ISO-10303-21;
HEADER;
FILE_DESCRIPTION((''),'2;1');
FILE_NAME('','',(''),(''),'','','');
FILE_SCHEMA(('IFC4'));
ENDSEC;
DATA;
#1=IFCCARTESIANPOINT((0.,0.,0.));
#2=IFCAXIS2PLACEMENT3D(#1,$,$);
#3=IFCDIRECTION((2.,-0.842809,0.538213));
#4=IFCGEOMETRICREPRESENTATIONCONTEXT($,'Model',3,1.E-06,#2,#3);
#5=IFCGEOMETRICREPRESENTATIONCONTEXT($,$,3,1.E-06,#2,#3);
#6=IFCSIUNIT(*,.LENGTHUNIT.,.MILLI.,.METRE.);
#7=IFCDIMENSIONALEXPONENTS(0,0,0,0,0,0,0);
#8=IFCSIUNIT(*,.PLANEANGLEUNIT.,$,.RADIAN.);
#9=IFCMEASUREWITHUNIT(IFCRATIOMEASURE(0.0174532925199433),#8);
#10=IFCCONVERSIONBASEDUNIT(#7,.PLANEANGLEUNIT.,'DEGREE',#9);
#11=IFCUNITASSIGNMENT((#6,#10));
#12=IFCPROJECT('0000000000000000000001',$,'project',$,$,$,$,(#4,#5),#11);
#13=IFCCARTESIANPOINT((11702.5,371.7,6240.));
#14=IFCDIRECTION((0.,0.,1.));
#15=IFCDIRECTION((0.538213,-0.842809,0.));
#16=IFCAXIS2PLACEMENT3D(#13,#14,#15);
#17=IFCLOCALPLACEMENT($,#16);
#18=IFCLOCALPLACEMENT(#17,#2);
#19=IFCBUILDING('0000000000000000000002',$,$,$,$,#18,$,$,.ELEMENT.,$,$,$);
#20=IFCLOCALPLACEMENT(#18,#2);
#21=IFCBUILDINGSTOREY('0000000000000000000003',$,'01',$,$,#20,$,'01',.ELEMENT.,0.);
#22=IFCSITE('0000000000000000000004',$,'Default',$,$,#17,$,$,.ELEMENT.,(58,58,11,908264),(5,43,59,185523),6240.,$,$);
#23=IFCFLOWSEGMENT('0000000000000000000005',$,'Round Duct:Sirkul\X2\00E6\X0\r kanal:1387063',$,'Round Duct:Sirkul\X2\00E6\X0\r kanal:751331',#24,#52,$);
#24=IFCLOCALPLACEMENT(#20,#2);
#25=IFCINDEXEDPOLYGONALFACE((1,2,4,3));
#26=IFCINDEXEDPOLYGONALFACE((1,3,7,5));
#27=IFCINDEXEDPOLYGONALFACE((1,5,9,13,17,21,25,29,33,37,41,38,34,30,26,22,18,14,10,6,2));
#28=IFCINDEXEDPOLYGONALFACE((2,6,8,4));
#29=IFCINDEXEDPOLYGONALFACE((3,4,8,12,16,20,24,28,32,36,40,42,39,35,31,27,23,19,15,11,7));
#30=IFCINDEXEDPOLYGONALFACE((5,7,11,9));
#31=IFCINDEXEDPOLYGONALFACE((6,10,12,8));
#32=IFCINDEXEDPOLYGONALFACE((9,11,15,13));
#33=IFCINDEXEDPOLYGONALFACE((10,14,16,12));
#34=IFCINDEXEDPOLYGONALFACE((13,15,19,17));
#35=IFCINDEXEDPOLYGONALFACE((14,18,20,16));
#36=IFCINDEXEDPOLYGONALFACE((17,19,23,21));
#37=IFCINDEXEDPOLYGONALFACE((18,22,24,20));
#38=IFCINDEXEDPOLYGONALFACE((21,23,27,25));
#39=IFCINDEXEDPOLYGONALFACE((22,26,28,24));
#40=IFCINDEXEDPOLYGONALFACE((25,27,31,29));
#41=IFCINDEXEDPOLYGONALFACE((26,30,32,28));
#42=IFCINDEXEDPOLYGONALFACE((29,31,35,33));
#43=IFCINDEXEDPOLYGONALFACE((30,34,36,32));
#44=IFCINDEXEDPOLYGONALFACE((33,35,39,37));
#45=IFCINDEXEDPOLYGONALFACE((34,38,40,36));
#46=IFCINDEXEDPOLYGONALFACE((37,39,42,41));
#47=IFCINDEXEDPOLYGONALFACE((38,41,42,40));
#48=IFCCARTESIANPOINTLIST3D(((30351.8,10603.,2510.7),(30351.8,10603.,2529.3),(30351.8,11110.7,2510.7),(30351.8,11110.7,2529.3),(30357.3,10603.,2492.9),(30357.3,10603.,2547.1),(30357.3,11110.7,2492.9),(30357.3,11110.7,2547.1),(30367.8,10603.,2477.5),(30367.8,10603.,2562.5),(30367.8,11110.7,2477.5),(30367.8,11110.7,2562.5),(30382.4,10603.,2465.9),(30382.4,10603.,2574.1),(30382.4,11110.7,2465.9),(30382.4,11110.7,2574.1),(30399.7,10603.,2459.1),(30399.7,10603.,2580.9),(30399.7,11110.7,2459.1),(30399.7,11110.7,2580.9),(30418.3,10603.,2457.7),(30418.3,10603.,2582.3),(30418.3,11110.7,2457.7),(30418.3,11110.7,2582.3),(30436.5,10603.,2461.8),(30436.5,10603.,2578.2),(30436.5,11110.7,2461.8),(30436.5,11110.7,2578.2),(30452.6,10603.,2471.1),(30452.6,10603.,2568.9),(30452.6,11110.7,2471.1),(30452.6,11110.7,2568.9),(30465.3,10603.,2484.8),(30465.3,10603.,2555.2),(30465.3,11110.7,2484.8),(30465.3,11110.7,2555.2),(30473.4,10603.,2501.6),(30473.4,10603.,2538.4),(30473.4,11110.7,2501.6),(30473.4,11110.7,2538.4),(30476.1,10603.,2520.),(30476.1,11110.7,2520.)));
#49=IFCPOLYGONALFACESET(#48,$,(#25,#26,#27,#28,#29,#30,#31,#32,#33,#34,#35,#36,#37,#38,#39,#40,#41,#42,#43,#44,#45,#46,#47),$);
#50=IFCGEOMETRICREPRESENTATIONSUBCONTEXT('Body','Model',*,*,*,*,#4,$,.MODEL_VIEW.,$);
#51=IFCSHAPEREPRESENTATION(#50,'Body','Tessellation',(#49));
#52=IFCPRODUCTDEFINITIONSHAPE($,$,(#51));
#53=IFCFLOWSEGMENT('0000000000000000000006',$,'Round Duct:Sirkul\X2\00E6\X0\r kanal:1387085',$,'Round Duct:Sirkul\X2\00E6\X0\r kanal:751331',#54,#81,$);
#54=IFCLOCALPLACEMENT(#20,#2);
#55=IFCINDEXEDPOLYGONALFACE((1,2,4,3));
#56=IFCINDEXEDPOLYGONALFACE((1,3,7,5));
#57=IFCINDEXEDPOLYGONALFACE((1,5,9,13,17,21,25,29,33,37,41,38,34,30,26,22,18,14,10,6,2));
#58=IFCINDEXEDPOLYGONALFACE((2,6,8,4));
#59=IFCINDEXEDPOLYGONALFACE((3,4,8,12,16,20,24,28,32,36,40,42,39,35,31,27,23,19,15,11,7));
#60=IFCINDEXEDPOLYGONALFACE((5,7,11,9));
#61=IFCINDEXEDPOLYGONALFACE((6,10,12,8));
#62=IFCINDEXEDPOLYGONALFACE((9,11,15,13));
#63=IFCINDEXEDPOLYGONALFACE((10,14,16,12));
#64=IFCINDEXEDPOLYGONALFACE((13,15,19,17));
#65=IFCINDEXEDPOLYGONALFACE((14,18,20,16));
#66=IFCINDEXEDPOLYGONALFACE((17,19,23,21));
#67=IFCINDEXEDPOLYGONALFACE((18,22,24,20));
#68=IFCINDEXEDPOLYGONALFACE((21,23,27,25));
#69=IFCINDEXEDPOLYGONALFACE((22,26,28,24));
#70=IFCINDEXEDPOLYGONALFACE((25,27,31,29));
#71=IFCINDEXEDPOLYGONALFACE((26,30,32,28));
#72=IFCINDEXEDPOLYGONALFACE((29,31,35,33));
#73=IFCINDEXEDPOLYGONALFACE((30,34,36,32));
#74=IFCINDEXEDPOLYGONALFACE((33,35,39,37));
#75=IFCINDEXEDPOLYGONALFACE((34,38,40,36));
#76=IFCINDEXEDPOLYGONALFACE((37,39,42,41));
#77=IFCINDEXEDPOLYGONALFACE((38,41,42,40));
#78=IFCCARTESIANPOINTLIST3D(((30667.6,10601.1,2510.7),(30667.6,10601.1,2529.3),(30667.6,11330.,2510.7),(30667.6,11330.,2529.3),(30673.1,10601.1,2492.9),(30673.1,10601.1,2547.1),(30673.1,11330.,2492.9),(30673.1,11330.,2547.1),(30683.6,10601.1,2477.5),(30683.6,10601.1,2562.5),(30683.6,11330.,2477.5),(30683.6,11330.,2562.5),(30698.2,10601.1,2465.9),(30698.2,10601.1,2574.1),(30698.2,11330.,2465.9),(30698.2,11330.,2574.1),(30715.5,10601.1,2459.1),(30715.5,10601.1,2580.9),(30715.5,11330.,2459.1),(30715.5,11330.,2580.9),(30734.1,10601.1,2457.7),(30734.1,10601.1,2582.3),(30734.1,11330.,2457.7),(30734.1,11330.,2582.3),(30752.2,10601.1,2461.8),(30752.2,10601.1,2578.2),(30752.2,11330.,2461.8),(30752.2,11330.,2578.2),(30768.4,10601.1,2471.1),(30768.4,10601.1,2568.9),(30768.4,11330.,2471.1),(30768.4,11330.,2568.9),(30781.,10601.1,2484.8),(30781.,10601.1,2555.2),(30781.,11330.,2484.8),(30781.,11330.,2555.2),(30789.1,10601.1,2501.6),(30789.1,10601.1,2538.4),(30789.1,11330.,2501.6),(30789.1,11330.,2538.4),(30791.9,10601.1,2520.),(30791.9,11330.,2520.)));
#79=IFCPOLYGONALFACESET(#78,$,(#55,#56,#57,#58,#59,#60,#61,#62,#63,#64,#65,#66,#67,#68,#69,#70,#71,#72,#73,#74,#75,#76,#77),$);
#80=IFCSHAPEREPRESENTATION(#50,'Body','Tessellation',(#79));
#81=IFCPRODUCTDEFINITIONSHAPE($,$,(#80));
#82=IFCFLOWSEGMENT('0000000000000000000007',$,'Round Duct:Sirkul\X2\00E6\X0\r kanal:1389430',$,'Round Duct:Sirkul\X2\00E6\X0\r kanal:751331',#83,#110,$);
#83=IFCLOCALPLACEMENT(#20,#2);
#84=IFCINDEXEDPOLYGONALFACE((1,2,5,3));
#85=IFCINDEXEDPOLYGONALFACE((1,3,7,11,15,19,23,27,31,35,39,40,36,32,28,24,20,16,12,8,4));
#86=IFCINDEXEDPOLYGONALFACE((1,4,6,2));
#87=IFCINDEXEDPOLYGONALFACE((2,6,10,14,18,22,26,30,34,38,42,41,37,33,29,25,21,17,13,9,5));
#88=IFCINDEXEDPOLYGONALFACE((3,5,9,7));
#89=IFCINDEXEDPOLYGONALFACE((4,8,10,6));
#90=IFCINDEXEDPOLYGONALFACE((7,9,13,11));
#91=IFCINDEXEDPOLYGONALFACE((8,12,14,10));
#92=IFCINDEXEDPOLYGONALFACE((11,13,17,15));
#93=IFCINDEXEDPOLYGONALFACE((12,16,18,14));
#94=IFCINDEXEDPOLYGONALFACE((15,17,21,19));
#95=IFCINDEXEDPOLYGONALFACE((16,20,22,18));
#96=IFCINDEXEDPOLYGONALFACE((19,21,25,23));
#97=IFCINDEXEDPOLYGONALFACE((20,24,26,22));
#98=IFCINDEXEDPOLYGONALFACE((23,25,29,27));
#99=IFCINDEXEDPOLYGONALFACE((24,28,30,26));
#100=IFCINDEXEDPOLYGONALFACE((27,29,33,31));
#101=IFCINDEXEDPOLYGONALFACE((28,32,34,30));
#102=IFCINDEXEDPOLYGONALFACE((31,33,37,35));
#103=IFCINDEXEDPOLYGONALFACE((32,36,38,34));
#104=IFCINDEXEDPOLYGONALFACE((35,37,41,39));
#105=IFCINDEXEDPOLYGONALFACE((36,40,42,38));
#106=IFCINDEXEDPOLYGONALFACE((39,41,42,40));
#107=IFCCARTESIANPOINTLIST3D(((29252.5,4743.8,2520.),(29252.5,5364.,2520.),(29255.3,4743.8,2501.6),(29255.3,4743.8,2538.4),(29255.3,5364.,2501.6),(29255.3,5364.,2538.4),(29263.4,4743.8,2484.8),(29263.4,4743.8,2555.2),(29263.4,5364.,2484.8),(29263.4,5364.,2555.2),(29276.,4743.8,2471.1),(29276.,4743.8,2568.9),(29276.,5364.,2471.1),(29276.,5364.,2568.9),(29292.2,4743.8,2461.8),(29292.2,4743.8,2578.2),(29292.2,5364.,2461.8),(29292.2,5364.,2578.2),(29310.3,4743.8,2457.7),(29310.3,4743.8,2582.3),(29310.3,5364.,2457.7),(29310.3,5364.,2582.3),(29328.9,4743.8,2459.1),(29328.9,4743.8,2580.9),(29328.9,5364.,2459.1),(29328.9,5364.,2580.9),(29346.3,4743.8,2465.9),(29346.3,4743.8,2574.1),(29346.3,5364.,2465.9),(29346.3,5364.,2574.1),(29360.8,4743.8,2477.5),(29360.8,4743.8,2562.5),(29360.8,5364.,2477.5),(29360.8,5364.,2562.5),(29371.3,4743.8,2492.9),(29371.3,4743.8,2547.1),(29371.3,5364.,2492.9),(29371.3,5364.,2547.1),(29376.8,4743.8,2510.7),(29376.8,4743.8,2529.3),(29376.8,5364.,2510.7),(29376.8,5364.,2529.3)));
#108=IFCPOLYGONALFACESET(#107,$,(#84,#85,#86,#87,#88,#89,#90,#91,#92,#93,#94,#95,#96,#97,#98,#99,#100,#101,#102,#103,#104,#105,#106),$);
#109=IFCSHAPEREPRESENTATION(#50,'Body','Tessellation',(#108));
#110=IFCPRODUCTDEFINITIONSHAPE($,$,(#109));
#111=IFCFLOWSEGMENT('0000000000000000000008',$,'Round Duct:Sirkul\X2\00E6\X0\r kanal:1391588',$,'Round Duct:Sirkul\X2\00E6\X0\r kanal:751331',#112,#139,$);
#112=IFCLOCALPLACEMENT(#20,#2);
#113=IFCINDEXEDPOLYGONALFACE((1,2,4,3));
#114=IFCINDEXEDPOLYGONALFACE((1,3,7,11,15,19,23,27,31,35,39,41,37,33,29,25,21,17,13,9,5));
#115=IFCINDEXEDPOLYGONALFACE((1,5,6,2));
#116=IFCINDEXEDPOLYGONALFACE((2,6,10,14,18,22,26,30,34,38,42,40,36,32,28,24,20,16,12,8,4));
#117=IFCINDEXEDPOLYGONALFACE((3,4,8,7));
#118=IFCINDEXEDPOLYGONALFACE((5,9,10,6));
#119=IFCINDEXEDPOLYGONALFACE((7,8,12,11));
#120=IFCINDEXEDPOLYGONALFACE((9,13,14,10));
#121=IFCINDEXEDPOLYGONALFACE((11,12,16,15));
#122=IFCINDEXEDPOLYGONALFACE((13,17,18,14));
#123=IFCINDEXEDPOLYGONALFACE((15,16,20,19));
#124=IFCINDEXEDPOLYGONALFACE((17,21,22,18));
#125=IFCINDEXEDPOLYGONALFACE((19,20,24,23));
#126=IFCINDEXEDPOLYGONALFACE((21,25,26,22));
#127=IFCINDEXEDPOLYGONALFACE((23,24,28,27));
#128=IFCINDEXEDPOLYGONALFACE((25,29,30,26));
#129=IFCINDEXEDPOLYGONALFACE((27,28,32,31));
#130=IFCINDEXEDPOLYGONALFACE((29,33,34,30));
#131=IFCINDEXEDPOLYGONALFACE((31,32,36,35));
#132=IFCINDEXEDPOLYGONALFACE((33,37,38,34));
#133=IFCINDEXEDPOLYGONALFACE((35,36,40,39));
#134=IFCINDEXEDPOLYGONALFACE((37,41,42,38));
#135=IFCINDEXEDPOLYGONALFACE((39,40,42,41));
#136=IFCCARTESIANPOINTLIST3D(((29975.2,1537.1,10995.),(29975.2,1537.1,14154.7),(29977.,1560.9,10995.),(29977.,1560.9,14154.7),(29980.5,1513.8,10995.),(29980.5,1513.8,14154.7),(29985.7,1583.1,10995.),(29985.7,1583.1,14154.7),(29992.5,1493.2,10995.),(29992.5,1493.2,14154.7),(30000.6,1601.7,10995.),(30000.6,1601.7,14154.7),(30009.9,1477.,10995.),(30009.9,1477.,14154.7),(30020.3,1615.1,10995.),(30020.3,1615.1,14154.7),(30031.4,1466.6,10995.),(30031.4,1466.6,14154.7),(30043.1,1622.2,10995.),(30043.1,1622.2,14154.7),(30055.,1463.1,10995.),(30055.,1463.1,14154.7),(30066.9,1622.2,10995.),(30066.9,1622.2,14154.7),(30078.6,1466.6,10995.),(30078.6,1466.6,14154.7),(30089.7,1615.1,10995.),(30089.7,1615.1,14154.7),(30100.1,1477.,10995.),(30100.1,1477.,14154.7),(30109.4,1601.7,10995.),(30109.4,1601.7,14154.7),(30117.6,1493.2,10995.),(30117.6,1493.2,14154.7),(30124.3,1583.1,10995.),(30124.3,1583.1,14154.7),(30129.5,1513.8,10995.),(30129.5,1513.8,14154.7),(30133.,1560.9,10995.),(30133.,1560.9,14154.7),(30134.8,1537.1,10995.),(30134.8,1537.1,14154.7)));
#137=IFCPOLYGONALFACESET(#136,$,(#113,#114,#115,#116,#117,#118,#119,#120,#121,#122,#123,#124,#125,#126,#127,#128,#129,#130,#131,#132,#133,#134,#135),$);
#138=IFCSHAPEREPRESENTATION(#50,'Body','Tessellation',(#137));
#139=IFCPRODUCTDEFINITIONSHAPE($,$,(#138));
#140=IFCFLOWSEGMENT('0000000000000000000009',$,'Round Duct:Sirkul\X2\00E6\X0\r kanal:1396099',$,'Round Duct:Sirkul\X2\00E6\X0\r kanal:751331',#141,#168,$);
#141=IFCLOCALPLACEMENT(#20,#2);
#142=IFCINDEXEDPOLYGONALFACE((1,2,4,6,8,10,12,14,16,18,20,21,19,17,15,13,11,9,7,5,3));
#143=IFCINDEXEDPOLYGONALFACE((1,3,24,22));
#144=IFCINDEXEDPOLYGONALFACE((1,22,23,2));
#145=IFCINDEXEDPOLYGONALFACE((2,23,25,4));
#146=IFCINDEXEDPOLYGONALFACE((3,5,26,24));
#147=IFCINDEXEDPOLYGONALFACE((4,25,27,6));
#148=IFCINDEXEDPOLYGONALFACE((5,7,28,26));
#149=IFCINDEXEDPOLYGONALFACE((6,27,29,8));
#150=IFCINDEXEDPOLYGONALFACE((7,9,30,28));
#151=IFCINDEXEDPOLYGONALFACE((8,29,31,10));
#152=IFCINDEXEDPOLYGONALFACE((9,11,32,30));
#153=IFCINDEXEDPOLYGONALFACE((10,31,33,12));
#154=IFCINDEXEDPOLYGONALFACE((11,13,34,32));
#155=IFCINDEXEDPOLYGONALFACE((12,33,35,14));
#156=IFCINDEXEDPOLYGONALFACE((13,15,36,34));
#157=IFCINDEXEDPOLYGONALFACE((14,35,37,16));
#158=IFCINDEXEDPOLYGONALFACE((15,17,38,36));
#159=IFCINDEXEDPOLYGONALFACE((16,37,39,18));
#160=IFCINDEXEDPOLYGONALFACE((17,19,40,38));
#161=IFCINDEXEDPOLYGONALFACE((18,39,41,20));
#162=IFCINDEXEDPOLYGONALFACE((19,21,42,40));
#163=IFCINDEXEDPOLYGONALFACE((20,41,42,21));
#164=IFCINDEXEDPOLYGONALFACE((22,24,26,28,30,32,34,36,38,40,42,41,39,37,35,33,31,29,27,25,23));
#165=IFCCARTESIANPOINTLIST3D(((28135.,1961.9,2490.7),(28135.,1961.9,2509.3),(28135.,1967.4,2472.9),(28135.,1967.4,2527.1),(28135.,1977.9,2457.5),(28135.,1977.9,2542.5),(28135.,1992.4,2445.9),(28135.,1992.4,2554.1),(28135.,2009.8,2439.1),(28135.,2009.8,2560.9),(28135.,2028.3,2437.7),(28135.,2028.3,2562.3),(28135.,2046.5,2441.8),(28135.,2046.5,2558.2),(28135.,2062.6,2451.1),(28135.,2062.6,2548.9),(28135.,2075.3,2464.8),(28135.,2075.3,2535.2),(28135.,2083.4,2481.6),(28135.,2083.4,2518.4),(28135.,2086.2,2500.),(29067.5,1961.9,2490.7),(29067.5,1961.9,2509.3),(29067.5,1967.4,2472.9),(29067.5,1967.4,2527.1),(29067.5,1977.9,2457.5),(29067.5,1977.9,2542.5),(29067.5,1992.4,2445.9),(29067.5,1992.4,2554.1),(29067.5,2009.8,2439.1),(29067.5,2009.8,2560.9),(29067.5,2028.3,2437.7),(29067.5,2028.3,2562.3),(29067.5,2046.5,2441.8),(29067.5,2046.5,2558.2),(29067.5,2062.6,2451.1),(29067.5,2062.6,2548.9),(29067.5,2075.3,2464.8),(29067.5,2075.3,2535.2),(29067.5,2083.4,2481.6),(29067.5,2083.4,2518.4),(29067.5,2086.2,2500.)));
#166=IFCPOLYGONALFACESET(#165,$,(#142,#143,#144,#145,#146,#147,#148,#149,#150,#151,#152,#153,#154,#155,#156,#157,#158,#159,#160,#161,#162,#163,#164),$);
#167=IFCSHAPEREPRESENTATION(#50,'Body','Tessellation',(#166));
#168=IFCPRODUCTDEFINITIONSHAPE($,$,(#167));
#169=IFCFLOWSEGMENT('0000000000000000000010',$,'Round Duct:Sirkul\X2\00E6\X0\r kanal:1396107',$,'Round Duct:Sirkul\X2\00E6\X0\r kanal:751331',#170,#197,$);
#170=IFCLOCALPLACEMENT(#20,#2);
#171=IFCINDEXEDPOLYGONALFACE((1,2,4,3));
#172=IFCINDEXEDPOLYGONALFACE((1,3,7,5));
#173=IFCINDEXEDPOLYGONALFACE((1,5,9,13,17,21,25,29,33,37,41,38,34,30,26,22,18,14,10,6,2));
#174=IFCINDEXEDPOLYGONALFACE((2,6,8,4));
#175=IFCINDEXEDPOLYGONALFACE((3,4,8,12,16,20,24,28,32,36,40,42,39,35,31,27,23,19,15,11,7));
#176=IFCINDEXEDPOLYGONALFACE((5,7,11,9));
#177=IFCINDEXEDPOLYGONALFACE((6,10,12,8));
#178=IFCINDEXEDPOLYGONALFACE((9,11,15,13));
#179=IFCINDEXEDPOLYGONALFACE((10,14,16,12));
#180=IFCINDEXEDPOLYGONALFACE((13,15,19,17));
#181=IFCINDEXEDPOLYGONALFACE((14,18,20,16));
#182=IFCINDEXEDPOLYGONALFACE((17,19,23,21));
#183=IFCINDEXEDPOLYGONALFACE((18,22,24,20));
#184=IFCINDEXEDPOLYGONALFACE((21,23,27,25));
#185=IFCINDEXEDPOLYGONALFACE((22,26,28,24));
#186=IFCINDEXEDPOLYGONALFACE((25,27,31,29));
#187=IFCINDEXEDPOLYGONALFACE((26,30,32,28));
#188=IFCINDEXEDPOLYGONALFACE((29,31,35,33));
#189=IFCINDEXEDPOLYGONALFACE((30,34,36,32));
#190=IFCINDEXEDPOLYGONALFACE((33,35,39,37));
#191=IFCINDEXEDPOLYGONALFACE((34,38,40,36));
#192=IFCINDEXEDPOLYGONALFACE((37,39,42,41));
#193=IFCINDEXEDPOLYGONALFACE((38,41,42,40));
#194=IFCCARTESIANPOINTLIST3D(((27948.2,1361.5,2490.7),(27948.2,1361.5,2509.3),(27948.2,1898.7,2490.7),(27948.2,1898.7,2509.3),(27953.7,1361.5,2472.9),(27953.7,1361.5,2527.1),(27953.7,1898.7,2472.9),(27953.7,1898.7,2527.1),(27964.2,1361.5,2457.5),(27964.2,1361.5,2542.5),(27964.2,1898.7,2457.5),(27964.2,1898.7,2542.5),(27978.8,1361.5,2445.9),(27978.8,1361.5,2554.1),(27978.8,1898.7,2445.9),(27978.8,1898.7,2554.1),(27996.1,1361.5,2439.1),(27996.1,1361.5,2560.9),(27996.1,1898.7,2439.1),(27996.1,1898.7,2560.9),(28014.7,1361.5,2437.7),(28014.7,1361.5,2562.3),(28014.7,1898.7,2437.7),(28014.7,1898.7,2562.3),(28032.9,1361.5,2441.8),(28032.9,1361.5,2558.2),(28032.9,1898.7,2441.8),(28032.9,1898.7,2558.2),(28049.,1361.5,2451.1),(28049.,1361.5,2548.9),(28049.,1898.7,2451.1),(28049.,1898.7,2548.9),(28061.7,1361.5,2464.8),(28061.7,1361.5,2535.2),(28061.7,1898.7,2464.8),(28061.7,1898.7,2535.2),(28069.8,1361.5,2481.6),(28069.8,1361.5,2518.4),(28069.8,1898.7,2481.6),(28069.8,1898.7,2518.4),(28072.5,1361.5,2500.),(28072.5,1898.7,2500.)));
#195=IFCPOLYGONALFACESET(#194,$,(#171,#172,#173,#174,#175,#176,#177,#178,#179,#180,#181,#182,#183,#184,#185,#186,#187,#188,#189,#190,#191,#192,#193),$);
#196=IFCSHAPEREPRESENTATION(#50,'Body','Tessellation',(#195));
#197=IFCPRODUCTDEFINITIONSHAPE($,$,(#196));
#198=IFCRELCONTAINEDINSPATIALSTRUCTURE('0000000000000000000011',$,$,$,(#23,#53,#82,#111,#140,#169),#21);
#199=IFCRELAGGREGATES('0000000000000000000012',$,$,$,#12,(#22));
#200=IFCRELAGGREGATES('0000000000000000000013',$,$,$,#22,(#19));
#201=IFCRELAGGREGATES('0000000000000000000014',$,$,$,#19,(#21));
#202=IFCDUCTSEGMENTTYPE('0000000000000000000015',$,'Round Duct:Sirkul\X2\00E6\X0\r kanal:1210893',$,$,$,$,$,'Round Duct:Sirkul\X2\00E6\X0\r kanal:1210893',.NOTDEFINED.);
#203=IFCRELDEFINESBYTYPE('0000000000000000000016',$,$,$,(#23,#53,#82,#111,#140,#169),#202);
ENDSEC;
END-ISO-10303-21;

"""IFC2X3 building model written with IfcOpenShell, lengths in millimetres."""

from ifc_helpers import new_model, entity, si_unit, converted_unit, direction, frame, frame_2d, origin, origin_2d_with_axis, place, context, subcontext, project, spatial, circle, extrude, type_object, element, save


model = new_model("IFC2X3")

# Units and contexts
model_context = context("Model", 3, precision=1e-06, world=origin(), true_north=direction((2.0, -0.842809, 0.538213)))
context_of_model = context(None, 3, precision=1e-06, world=origin(), true_north=direction((2.0, -0.842809, 0.538213)))
body_context = subcontext(model_context, "Body", "Model", "MODEL_VIEW")
ifc_project = project(units=[si_unit("LENGTHUNIT", "METRE", prefix="MILLI"), converted_unit("PLANEANGLEUNIT", "DEGREE", entity("IfcRatioMeasure", 0.0174532925199433), si_unit("PLANEANGLEUNIT", "RADIAN"), dimensions=[0, 0, 0, 0, 0, 0, 0])], contexts=[model_context, context_of_model])

# Site, building, storey
site_placement = place(None, frame((11702.5, 371.7, 6240.0), z_axis=(0.0, 0.0, 1.0), x_axis=(0.538213, -0.842809, 0.0)))
site = spatial("IfcSite", under=ifc_project, at=site_placement, Name="Default", CompositionType="ELEMENT", RefLatitude=(58, 58, 11, 908264), RefLongitude=(5, 43, 59, 185523), RefElevation=6240.0)
building_placement = place(site_placement, origin())
building = spatial("IfcBuilding", under=site, at=building_placement, CompositionType="ELEMENT")
storey_placement = place(building_placement, origin())
storey = spatial("IfcBuildingStorey", under=building, at=storey_placement, Name="01", LongName="01", CompositionType="ELEMENT", Elevation=0.0)

# Flow segments
duct_segment_type_1 = type_object("IfcDuctSegmentType", Name="Round Duct:Sirkulær kanal:1210893", ElementType="Round Duct:Sirkulær kanal:1210893", PredefinedType="NOTDEFINED")
flow_segment_1_placement = place(storey_placement, origin())
element("IfcFlowSegment", 1, at=flow_segment_1_placement, inside=storey, type_object=duct_segment_type_1, Name="Round Duct:Sirkulær kanal:1387063", ObjectType="Round Duct:Sirkulær kanal:751331", context=body_context, shape_type="SweptSolid", body=[
    extrude(circle(Radius=62.5, at=origin_2d_with_axis()), frame((30413.6, 10603.0, 2520.0), z_axis=(0.0, 1.0, 0.0), x_axis=(1.0, 0.0, 0.0)), (0.0, 0.0, 1.0), 507.7),
])
flow_segment_2_placement = place(storey_placement, origin())
element("IfcFlowSegment", 2, at=flow_segment_2_placement, inside=storey, type_object=duct_segment_type_1, Name="Round Duct:Sirkulær kanal:1387085", ObjectType="Round Duct:Sirkulær kanal:751331", context=body_context, shape_type="SweptSolid", body=[
    extrude(circle(Radius=62.5, at=origin_2d_with_axis()), frame((30729.4, 10601.1, 2520.0), z_axis=(0.0, 1.0, 0.0), x_axis=(1.0, 0.0, 0.0)), (0.0, 0.0, 1.0), 728.9),
])
flow_segment_3_placement = place(storey_placement, origin())
element("IfcFlowSegment", 3, at=flow_segment_3_placement, inside=storey, type_object=duct_segment_type_1, Name="Round Duct:Sirkulær kanal:1389430", ObjectType="Round Duct:Sirkulær kanal:751331", context=body_context, shape_type="SweptSolid", body=[
    extrude(circle(Radius=62.5, at=origin_2d_with_axis()), frame((29315.0, 4743.8, 2520.0), z_axis=(0.0, 1.0, 0.0), x_axis=(-1.0, 0.0, 0.0)), (0.0, 0.0, 1.0), 620.2),
])
flow_segment_4_placement = place(storey_placement, origin())
element("IfcFlowSegment", 4, at=flow_segment_4_placement, inside=storey, type_object=duct_segment_type_1, Name="Round Duct:Sirkulær kanal:1391588", ObjectType="Round Duct:Sirkulær kanal:751331", context=body_context, shape_type="SweptSolid", body=[
    extrude(circle(Radius=80.0, at=frame_2d((0.0, 0.0), x_axis=(1.0, 0.0))), frame((30055.0, 1543.1, 10995.0), z_axis=(0.0, 0.0, 1.0), x_axis=(0.0, -1.0, 0.0)), (0.0, 0.0, 1.0), 3159.7),
])
flow_segment_5_placement = place(storey_placement, origin())
element("IfcFlowSegment", 5, at=flow_segment_5_placement, inside=storey, type_object=duct_segment_type_1, Name="Round Duct:Sirkulær kanal:1396099", ObjectType="Round Duct:Sirkulær kanal:751331", context=body_context, shape_type="SweptSolid", body=[
    extrude(circle(Radius=62.5, at=frame_2d((0.0, 0.0), x_axis=(1.0, 0.0))), frame((28135.0, 2023.7, 2500.0), z_axis=(1.0, 0.0, 0.0), x_axis=(0.0, 1.0, 0.0)), (0.0, 0.0, 1.0), 932.5),
])
flow_segment_6_placement = place(storey_placement, origin())
element("IfcFlowSegment", 6, at=flow_segment_6_placement, inside=storey, type_object=duct_segment_type_1, Name="Round Duct:Sirkulær kanal:1396107", ObjectType="Round Duct:Sirkulær kanal:751331", context=body_context, shape_type="SweptSolid", body=[
    extrude(circle(Radius=62.5, at=origin_2d_with_axis()), frame((28010.0, 1361.5, 2500.0), z_axis=(0.0, 1.0, 0.0), x_axis=(1.0, 0.0, 0.0)), (0.0, 0.0, 1.0), 537.2),
])

save(model, "model.ifc")
